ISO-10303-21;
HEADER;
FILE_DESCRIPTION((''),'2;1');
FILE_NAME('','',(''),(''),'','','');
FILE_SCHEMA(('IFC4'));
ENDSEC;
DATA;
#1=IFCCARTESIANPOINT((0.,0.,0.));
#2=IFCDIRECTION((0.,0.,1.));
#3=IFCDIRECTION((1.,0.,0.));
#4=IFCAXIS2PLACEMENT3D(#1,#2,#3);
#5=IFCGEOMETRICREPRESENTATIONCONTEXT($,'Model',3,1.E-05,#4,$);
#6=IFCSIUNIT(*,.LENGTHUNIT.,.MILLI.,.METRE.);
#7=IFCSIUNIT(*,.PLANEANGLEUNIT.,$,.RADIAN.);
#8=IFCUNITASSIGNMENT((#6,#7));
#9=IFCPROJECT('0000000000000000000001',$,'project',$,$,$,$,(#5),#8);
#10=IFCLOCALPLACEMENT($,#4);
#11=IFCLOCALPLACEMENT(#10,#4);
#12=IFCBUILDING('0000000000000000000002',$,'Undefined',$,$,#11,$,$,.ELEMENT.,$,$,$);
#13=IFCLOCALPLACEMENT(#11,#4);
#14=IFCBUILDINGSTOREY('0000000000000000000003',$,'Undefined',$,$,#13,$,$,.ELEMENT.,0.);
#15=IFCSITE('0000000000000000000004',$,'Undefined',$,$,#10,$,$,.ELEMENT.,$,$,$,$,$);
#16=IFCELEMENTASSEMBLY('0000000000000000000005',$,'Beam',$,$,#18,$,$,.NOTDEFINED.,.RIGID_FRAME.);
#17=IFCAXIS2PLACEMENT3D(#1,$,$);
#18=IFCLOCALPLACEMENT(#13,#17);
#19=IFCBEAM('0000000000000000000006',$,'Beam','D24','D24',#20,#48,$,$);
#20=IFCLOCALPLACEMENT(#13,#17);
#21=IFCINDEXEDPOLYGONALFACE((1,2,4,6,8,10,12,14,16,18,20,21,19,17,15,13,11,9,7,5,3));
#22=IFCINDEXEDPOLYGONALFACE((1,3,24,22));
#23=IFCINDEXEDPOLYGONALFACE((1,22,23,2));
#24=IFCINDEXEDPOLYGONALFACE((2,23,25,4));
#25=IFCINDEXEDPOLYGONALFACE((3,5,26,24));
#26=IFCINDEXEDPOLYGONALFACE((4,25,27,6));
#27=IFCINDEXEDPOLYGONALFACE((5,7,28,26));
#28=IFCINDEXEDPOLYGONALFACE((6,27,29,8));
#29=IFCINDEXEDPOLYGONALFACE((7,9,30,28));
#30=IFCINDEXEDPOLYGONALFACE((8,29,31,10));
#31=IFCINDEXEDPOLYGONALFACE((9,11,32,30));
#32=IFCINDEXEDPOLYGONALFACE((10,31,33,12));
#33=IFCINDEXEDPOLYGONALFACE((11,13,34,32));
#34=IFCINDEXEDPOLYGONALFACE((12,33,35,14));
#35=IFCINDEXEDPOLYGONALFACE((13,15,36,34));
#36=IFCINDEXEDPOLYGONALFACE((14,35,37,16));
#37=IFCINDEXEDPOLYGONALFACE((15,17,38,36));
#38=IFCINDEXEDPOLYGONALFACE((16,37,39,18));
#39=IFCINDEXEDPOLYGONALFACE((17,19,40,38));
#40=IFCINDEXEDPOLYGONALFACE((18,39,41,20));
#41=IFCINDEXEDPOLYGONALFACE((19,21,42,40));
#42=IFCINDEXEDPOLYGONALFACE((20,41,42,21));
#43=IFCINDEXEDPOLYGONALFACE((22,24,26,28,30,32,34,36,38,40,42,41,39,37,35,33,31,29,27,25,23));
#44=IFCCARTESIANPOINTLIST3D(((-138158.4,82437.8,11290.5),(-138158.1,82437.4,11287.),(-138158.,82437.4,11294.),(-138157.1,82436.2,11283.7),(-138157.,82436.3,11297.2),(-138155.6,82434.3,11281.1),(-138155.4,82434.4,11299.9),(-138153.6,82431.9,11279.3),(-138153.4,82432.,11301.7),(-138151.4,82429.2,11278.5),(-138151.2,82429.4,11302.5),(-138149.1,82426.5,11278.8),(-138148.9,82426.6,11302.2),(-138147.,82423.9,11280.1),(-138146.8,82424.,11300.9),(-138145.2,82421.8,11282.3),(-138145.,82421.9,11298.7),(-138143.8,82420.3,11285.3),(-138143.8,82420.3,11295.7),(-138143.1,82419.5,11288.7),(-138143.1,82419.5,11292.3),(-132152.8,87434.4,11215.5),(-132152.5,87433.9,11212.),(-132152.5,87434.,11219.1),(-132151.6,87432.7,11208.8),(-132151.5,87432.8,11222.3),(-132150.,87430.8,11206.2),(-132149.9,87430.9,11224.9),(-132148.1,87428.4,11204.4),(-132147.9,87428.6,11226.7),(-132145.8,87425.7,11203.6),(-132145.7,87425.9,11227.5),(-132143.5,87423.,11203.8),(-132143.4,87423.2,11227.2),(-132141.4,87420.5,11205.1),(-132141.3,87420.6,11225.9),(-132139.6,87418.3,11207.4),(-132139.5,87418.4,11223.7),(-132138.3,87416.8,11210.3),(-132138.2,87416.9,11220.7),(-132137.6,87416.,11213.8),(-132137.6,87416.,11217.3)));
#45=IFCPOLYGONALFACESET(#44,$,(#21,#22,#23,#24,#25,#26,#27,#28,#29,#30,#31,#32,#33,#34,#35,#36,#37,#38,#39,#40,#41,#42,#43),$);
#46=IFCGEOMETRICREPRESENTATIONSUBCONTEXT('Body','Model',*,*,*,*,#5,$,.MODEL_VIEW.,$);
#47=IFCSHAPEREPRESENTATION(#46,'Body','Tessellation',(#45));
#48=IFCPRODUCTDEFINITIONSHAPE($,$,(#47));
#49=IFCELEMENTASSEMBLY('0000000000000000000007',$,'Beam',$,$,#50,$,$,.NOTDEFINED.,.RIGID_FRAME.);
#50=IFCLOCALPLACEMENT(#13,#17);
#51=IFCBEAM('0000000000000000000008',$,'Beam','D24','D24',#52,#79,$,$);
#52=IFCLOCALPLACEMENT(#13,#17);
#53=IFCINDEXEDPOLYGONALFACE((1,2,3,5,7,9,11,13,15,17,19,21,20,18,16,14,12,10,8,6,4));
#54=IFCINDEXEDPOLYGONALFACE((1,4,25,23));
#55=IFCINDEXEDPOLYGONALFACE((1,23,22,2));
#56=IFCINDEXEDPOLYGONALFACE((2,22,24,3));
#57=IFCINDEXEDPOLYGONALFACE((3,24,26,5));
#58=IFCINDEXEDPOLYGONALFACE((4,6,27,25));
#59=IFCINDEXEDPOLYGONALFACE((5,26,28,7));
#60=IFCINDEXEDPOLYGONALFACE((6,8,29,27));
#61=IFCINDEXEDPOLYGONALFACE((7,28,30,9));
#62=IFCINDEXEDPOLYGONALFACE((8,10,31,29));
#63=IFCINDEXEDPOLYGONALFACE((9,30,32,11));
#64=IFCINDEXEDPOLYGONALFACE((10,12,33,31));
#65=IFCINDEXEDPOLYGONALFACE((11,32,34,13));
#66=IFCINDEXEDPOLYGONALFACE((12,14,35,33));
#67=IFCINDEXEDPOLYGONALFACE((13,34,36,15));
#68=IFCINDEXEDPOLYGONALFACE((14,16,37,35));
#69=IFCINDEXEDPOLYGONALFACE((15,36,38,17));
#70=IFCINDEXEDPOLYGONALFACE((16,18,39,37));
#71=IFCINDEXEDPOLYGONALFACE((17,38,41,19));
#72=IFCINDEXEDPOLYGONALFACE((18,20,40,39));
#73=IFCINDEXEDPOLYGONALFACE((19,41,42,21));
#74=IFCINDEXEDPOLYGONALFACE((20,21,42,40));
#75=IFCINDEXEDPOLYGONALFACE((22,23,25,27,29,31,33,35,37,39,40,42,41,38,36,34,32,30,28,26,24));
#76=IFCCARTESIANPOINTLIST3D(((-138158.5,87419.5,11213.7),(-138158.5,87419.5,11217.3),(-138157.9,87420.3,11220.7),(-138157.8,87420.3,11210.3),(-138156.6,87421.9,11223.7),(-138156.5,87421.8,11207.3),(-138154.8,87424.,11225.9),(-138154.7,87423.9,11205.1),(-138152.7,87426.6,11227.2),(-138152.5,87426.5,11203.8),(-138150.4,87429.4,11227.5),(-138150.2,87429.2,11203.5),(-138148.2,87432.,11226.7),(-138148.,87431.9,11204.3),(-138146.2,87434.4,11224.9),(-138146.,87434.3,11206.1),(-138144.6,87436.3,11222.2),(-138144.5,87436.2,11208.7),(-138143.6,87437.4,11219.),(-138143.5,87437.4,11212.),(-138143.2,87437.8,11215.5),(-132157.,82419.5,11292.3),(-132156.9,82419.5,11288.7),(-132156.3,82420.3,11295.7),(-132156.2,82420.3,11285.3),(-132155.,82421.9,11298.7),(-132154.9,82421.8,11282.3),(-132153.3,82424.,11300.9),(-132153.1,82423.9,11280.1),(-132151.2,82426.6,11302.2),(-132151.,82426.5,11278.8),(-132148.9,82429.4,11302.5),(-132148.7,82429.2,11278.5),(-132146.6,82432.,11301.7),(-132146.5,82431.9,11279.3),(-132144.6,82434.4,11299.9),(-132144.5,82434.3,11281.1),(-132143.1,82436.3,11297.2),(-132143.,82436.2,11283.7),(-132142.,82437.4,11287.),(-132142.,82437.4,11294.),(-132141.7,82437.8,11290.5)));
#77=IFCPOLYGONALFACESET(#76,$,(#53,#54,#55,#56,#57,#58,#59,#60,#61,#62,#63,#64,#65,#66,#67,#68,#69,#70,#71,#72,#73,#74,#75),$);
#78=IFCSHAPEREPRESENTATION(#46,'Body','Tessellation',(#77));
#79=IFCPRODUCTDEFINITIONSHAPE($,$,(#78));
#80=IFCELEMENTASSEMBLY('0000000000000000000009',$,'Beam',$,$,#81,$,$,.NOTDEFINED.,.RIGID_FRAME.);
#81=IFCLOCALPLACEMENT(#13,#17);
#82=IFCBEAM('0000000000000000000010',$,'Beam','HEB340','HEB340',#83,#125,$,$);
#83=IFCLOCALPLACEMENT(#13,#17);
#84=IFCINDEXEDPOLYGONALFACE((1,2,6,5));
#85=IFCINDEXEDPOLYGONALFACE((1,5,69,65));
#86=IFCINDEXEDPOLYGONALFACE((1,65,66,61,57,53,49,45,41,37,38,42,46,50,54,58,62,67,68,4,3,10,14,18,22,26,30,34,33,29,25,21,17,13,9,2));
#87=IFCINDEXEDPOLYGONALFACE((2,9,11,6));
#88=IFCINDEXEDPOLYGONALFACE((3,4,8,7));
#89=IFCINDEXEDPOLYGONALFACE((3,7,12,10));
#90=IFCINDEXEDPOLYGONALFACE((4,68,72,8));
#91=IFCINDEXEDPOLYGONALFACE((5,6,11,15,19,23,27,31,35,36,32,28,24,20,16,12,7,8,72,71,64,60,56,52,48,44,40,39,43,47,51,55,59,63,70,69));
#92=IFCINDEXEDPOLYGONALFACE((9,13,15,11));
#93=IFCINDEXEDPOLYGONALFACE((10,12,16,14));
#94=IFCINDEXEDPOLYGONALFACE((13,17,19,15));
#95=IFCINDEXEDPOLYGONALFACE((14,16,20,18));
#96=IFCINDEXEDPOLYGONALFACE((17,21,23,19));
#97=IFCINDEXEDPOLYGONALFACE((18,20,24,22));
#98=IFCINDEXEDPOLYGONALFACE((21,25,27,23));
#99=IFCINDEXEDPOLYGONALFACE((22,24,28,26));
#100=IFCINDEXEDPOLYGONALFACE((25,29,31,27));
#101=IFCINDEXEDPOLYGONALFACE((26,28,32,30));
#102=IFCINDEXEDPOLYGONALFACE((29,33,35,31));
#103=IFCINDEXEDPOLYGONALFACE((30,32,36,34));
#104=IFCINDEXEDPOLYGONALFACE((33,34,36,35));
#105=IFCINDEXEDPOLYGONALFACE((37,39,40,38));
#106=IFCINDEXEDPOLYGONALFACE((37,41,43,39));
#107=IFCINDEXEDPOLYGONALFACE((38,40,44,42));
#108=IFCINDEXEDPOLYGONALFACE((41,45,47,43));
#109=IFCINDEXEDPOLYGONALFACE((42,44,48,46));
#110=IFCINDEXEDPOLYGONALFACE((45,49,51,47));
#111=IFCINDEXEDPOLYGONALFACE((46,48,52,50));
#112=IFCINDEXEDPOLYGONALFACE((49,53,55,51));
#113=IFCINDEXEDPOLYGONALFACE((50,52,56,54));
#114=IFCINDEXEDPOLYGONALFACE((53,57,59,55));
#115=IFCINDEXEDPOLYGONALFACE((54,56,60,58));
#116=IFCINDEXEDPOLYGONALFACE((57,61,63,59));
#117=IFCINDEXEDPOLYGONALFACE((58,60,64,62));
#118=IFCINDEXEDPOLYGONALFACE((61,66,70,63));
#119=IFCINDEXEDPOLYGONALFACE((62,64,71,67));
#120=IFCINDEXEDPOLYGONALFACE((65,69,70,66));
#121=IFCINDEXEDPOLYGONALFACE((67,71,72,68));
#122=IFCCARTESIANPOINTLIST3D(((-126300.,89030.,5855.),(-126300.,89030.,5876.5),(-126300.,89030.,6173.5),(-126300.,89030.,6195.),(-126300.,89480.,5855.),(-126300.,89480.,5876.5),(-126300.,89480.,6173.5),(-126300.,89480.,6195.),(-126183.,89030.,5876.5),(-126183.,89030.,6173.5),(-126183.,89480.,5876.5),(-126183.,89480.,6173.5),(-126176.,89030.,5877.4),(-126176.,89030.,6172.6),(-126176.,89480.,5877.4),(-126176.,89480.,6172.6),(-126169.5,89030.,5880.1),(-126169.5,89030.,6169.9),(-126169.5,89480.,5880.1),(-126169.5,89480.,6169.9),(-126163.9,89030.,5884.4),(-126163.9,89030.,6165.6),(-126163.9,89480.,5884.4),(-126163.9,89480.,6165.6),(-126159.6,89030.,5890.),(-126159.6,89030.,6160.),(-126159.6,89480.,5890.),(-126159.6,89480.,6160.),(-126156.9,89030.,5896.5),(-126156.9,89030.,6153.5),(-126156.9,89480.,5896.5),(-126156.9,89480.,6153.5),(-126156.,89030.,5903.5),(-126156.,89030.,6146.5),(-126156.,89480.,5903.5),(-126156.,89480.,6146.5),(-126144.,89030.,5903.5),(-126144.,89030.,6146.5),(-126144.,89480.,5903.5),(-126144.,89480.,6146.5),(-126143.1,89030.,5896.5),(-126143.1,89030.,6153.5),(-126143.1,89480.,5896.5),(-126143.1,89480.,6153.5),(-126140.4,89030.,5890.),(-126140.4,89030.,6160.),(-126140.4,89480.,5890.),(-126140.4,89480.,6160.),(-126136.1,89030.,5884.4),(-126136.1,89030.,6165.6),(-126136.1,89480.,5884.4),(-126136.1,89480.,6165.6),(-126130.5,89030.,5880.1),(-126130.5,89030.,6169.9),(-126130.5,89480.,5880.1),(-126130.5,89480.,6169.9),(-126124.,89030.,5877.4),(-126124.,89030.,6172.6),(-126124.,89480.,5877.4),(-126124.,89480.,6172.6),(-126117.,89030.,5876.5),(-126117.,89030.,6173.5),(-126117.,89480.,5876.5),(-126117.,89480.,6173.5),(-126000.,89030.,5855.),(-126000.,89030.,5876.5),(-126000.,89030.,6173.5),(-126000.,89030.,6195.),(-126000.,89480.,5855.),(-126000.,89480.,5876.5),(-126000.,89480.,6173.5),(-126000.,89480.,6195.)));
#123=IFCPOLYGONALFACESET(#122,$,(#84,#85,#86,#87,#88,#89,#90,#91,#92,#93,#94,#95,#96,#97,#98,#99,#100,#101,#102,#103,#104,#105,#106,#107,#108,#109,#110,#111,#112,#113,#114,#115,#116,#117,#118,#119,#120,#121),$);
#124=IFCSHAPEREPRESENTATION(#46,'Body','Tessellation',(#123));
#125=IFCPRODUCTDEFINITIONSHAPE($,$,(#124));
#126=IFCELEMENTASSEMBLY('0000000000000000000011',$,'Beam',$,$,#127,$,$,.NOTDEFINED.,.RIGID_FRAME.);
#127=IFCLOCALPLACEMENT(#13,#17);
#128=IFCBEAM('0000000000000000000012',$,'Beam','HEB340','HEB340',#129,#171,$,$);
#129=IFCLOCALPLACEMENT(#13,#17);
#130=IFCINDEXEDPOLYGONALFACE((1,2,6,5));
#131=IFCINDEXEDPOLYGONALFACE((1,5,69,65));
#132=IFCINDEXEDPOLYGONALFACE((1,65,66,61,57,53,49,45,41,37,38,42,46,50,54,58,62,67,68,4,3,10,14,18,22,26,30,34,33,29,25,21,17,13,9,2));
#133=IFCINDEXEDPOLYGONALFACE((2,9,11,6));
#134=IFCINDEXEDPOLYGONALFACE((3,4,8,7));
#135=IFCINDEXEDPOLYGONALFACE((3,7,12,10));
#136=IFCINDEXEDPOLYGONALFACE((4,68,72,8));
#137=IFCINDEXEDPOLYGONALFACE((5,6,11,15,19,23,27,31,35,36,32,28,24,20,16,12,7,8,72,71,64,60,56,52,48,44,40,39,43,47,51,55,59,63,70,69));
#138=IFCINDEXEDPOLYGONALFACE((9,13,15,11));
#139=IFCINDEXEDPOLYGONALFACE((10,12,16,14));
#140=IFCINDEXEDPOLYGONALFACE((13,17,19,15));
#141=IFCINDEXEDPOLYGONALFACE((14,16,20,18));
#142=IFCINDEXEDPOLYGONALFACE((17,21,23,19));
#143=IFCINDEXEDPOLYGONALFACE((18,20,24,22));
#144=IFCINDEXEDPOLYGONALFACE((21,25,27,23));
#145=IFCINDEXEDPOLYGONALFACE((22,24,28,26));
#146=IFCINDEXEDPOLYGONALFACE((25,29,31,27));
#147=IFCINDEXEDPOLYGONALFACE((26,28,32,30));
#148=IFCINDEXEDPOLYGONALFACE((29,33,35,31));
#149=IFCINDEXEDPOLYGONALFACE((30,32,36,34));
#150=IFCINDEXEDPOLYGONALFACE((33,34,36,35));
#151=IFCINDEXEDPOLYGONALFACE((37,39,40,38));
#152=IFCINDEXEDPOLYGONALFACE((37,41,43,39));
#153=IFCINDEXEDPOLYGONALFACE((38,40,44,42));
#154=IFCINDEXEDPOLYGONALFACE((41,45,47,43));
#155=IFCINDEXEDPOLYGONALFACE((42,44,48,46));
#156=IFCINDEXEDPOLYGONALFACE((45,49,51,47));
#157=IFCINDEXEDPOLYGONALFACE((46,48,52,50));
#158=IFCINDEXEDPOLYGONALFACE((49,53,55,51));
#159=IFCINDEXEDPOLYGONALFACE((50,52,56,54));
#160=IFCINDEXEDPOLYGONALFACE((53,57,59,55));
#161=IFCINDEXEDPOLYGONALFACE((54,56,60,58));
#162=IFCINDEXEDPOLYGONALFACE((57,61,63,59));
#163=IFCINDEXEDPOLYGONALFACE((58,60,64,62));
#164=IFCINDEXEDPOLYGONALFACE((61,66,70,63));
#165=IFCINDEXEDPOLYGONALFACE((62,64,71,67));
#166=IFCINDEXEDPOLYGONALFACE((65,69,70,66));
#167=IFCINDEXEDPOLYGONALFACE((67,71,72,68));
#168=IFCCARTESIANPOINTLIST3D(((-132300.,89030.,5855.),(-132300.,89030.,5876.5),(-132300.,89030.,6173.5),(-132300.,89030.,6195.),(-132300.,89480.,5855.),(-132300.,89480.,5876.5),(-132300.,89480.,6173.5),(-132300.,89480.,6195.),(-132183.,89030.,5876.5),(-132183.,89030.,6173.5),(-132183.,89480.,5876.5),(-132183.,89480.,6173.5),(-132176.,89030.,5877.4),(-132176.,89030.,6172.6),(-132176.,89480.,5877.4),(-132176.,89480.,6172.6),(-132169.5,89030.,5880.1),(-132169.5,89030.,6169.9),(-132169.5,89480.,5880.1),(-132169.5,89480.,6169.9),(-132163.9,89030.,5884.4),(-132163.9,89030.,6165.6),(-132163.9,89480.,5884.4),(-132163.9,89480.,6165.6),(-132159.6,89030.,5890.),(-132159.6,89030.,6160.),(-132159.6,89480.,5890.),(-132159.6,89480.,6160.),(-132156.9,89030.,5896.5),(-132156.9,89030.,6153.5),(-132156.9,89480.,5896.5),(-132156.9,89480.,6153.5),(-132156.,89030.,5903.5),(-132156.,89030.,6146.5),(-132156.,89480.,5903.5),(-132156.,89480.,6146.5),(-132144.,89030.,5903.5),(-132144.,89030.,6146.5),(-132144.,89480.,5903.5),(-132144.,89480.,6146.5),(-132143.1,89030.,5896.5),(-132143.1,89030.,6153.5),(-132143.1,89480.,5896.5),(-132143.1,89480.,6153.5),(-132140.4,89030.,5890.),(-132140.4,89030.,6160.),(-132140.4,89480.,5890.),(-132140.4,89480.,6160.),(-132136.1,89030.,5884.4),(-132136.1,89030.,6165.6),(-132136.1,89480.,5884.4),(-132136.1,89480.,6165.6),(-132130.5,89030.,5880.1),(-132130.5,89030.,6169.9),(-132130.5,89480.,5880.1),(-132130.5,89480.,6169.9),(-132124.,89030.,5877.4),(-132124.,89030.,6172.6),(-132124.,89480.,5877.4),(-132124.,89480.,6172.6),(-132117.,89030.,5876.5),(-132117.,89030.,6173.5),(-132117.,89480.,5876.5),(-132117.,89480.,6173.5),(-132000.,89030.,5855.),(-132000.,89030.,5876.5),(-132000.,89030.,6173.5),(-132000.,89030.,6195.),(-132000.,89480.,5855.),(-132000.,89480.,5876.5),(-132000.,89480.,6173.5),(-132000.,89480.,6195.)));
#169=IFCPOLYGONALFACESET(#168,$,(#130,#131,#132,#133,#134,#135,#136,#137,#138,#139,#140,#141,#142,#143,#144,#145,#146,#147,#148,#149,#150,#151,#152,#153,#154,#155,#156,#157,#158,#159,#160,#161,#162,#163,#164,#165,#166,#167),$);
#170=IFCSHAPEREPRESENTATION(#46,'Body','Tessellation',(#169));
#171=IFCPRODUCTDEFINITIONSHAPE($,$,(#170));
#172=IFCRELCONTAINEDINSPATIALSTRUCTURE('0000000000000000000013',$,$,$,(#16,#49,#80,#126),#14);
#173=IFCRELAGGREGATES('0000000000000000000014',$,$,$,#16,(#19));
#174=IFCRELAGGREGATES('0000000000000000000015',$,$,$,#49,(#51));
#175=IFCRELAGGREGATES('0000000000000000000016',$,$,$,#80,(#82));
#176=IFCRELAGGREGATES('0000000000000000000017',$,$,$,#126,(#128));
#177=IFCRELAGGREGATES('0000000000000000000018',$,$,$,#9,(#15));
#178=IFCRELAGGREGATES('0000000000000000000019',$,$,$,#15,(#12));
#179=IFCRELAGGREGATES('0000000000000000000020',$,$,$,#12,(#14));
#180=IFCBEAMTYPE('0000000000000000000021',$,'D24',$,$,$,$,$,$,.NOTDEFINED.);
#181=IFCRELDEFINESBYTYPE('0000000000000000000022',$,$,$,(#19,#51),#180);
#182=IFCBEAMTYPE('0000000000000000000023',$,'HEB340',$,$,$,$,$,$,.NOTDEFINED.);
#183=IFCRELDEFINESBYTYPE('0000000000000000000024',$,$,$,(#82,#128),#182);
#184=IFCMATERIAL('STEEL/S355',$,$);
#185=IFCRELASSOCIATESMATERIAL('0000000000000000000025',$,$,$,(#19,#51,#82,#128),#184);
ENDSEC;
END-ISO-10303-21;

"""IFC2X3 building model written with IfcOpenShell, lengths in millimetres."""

from ifc_helpers import new_model, si_unit, frame, origin_with_axes, origin_2d_with_axis, place, context, subcontext, project, spatial, circle, i_section, extrude, material, type_object, element, aggregate, save


model = new_model("IFC2X3")

# Units and contexts
model_context = context("Model", 3, precision=1e-05, world=origin_with_axes())
body_context = subcontext(model_context, "Body", "Model", "MODEL_VIEW")
ifc_project = project(units=[si_unit("LENGTHUNIT", "METRE", prefix="MILLI"), si_unit("PLANEANGLEUNIT", "RADIAN")], contexts=[model_context])

# Site, building, storey
site_placement = place(None, origin_with_axes())
site = spatial("IfcSite", under=ifc_project, at=site_placement, Name="Undefined", CompositionType="ELEMENT")
building_placement = place(site_placement, origin_with_axes())
building = spatial("IfcBuilding", under=site, at=building_placement, Name="Undefined", CompositionType="ELEMENT")
storey_placement = place(building_placement, origin_with_axes())
storey = spatial("IfcBuildingStorey", under=building, at=storey_placement, Name="Undefined", CompositionType="ELEMENT", Elevation=0.0)

# Element assemblies, beams
ifc_material_1 = material(Name="STEEL/S355")
assembly_1_placement = place(storey_placement, origin_with_axes())
assembly_1 = element("IfcElementAssembly", 1, at=assembly_1_placement, inside=storey, Name="Beam", AssemblyPlace="NOTDEFINED", PredefinedType="RIGID_FRAME")
beam_type_1 = type_object("IfcBeamType", Name="D24", PredefinedType="NOTDEFINED")
beam_1_placement = place(assembly_1_placement, frame((-132145.2, 87425.1, 11215.5), z_axis=(0.007375, 0.006136, 0.999954), x_axis=(-0.768695, -0.639544, 0.009593)))
beam_1 = element("IfcBeam", 2, at=beam_1_placement, type_object=beam_type_1, material=ifc_material_1, Name="Beam", Description="D24", ObjectType="D24", context=body_context, shape_type="SweptSolid", body=[
    extrude(circle(Radius=12.0, at=origin_2d_with_axis()), frame((7812.7, 0.0, 0.0), z_axis=(-1.0, 0.0, 0.0), x_axis=(0.0, -1.0, 0.0)), (0.0, 0.0, 1.0), 7812.7),
])
aggregate(assembly_1, [beam_1])
assembly_2_placement = place(storey_placement, origin_with_axes())
assembly_2 = element("IfcElementAssembly", 3, at=assembly_2_placement, inside=storey, Name="Beam", AssemblyPlace="NOTDEFINED", PredefinedType="RIGID_FRAME")
beam_2_placement = place(assembly_2_placement, frame((-132149.4, 82428.6, 11290.5), z_axis=(-0.007376, 0.006145, 0.999954), x_axis=(-0.768267, 0.640058, -0.009601)))
beam_2 = element("IfcBeam", 4, at=beam_2_placement, type_object=beam_type_1, material=ifc_material_1, Name="Beam", Description="D24", ObjectType="D24", context=body_context, shape_type="SweptSolid", body=[
    extrude(circle(Radius=12.0, at=origin_2d_with_axis()), frame((7811.8, 0.0, 0.0), z_axis=(-1.0, 0.0, 0.0), x_axis=(0.0, -1.0, 0.0)), (0.0, 0.0, 1.0), 7811.8),
])
aggregate(assembly_2, [beam_2])
assembly_3_placement = place(storey_placement, origin_with_axes())
assembly_3 = element("IfcElementAssembly", 5, at=assembly_3_placement, inside=storey, Name="Beam", AssemblyPlace="NOTDEFINED", PredefinedType="RIGID_FRAME")
beam_type_2 = type_object("IfcBeamType", Name="HEB340", PredefinedType="NOTDEFINED")
beam_3_placement = place(assembly_3_placement, frame((-126150.0, 89030.0, 6025.0), z_axis=(0.0, 0.0, 1.0), x_axis=(0.0, 1.0, 0.0)))
beam_3 = element("IfcBeam", 6, at=beam_3_placement, type_object=beam_type_2, material=ifc_material_1, Name="Beam", Description="HEB340", ObjectType="HEB340", context=body_context, shape_type="SweptSolid", body=[
    extrude(i_section(OverallWidth=300.0, OverallDepth=340.0, WebThickness=12.0, FlangeThickness=21.5, FilletRadius=27.0, at=origin_2d_with_axis()), frame((450.0, 0.0, 0.0), z_axis=(-1.0, 0.0, 0.0), x_axis=(0.0, -1.0, 0.0)), (0.0, 0.0, 1.0), 450.0),
])
aggregate(assembly_3, [beam_3])
assembly_4_placement = place(storey_placement, origin_with_axes())
assembly_4 = element("IfcElementAssembly", 7, at=assembly_4_placement, inside=storey, Name="Beam", AssemblyPlace="NOTDEFINED", PredefinedType="RIGID_FRAME")
beam_4_placement = place(assembly_4_placement, frame((-132150.0, 89030.0, 6025.0), z_axis=(0.0, 0.0, 1.0), x_axis=(0.0, 1.0, 0.0)))
beam_4 = element("IfcBeam", 8, at=beam_4_placement, type_object=beam_type_2, material=ifc_material_1, Name="Beam", Description="HEB340", ObjectType="HEB340", context=body_context, shape_type="SweptSolid", body=[
    extrude(i_section(OverallWidth=300.0, OverallDepth=340.0, WebThickness=12.0, FlangeThickness=21.5, FilletRadius=27.0, at=origin_2d_with_axis()), frame((450.0, 0.0, 0.0), z_axis=(-1.0, 0.0, 0.0), x_axis=(0.0, -1.0, 0.0)), (0.0, 0.0, 1.0), 450.0),
])
aggregate(assembly_4, [beam_4])

save(model, "model.ifc")
